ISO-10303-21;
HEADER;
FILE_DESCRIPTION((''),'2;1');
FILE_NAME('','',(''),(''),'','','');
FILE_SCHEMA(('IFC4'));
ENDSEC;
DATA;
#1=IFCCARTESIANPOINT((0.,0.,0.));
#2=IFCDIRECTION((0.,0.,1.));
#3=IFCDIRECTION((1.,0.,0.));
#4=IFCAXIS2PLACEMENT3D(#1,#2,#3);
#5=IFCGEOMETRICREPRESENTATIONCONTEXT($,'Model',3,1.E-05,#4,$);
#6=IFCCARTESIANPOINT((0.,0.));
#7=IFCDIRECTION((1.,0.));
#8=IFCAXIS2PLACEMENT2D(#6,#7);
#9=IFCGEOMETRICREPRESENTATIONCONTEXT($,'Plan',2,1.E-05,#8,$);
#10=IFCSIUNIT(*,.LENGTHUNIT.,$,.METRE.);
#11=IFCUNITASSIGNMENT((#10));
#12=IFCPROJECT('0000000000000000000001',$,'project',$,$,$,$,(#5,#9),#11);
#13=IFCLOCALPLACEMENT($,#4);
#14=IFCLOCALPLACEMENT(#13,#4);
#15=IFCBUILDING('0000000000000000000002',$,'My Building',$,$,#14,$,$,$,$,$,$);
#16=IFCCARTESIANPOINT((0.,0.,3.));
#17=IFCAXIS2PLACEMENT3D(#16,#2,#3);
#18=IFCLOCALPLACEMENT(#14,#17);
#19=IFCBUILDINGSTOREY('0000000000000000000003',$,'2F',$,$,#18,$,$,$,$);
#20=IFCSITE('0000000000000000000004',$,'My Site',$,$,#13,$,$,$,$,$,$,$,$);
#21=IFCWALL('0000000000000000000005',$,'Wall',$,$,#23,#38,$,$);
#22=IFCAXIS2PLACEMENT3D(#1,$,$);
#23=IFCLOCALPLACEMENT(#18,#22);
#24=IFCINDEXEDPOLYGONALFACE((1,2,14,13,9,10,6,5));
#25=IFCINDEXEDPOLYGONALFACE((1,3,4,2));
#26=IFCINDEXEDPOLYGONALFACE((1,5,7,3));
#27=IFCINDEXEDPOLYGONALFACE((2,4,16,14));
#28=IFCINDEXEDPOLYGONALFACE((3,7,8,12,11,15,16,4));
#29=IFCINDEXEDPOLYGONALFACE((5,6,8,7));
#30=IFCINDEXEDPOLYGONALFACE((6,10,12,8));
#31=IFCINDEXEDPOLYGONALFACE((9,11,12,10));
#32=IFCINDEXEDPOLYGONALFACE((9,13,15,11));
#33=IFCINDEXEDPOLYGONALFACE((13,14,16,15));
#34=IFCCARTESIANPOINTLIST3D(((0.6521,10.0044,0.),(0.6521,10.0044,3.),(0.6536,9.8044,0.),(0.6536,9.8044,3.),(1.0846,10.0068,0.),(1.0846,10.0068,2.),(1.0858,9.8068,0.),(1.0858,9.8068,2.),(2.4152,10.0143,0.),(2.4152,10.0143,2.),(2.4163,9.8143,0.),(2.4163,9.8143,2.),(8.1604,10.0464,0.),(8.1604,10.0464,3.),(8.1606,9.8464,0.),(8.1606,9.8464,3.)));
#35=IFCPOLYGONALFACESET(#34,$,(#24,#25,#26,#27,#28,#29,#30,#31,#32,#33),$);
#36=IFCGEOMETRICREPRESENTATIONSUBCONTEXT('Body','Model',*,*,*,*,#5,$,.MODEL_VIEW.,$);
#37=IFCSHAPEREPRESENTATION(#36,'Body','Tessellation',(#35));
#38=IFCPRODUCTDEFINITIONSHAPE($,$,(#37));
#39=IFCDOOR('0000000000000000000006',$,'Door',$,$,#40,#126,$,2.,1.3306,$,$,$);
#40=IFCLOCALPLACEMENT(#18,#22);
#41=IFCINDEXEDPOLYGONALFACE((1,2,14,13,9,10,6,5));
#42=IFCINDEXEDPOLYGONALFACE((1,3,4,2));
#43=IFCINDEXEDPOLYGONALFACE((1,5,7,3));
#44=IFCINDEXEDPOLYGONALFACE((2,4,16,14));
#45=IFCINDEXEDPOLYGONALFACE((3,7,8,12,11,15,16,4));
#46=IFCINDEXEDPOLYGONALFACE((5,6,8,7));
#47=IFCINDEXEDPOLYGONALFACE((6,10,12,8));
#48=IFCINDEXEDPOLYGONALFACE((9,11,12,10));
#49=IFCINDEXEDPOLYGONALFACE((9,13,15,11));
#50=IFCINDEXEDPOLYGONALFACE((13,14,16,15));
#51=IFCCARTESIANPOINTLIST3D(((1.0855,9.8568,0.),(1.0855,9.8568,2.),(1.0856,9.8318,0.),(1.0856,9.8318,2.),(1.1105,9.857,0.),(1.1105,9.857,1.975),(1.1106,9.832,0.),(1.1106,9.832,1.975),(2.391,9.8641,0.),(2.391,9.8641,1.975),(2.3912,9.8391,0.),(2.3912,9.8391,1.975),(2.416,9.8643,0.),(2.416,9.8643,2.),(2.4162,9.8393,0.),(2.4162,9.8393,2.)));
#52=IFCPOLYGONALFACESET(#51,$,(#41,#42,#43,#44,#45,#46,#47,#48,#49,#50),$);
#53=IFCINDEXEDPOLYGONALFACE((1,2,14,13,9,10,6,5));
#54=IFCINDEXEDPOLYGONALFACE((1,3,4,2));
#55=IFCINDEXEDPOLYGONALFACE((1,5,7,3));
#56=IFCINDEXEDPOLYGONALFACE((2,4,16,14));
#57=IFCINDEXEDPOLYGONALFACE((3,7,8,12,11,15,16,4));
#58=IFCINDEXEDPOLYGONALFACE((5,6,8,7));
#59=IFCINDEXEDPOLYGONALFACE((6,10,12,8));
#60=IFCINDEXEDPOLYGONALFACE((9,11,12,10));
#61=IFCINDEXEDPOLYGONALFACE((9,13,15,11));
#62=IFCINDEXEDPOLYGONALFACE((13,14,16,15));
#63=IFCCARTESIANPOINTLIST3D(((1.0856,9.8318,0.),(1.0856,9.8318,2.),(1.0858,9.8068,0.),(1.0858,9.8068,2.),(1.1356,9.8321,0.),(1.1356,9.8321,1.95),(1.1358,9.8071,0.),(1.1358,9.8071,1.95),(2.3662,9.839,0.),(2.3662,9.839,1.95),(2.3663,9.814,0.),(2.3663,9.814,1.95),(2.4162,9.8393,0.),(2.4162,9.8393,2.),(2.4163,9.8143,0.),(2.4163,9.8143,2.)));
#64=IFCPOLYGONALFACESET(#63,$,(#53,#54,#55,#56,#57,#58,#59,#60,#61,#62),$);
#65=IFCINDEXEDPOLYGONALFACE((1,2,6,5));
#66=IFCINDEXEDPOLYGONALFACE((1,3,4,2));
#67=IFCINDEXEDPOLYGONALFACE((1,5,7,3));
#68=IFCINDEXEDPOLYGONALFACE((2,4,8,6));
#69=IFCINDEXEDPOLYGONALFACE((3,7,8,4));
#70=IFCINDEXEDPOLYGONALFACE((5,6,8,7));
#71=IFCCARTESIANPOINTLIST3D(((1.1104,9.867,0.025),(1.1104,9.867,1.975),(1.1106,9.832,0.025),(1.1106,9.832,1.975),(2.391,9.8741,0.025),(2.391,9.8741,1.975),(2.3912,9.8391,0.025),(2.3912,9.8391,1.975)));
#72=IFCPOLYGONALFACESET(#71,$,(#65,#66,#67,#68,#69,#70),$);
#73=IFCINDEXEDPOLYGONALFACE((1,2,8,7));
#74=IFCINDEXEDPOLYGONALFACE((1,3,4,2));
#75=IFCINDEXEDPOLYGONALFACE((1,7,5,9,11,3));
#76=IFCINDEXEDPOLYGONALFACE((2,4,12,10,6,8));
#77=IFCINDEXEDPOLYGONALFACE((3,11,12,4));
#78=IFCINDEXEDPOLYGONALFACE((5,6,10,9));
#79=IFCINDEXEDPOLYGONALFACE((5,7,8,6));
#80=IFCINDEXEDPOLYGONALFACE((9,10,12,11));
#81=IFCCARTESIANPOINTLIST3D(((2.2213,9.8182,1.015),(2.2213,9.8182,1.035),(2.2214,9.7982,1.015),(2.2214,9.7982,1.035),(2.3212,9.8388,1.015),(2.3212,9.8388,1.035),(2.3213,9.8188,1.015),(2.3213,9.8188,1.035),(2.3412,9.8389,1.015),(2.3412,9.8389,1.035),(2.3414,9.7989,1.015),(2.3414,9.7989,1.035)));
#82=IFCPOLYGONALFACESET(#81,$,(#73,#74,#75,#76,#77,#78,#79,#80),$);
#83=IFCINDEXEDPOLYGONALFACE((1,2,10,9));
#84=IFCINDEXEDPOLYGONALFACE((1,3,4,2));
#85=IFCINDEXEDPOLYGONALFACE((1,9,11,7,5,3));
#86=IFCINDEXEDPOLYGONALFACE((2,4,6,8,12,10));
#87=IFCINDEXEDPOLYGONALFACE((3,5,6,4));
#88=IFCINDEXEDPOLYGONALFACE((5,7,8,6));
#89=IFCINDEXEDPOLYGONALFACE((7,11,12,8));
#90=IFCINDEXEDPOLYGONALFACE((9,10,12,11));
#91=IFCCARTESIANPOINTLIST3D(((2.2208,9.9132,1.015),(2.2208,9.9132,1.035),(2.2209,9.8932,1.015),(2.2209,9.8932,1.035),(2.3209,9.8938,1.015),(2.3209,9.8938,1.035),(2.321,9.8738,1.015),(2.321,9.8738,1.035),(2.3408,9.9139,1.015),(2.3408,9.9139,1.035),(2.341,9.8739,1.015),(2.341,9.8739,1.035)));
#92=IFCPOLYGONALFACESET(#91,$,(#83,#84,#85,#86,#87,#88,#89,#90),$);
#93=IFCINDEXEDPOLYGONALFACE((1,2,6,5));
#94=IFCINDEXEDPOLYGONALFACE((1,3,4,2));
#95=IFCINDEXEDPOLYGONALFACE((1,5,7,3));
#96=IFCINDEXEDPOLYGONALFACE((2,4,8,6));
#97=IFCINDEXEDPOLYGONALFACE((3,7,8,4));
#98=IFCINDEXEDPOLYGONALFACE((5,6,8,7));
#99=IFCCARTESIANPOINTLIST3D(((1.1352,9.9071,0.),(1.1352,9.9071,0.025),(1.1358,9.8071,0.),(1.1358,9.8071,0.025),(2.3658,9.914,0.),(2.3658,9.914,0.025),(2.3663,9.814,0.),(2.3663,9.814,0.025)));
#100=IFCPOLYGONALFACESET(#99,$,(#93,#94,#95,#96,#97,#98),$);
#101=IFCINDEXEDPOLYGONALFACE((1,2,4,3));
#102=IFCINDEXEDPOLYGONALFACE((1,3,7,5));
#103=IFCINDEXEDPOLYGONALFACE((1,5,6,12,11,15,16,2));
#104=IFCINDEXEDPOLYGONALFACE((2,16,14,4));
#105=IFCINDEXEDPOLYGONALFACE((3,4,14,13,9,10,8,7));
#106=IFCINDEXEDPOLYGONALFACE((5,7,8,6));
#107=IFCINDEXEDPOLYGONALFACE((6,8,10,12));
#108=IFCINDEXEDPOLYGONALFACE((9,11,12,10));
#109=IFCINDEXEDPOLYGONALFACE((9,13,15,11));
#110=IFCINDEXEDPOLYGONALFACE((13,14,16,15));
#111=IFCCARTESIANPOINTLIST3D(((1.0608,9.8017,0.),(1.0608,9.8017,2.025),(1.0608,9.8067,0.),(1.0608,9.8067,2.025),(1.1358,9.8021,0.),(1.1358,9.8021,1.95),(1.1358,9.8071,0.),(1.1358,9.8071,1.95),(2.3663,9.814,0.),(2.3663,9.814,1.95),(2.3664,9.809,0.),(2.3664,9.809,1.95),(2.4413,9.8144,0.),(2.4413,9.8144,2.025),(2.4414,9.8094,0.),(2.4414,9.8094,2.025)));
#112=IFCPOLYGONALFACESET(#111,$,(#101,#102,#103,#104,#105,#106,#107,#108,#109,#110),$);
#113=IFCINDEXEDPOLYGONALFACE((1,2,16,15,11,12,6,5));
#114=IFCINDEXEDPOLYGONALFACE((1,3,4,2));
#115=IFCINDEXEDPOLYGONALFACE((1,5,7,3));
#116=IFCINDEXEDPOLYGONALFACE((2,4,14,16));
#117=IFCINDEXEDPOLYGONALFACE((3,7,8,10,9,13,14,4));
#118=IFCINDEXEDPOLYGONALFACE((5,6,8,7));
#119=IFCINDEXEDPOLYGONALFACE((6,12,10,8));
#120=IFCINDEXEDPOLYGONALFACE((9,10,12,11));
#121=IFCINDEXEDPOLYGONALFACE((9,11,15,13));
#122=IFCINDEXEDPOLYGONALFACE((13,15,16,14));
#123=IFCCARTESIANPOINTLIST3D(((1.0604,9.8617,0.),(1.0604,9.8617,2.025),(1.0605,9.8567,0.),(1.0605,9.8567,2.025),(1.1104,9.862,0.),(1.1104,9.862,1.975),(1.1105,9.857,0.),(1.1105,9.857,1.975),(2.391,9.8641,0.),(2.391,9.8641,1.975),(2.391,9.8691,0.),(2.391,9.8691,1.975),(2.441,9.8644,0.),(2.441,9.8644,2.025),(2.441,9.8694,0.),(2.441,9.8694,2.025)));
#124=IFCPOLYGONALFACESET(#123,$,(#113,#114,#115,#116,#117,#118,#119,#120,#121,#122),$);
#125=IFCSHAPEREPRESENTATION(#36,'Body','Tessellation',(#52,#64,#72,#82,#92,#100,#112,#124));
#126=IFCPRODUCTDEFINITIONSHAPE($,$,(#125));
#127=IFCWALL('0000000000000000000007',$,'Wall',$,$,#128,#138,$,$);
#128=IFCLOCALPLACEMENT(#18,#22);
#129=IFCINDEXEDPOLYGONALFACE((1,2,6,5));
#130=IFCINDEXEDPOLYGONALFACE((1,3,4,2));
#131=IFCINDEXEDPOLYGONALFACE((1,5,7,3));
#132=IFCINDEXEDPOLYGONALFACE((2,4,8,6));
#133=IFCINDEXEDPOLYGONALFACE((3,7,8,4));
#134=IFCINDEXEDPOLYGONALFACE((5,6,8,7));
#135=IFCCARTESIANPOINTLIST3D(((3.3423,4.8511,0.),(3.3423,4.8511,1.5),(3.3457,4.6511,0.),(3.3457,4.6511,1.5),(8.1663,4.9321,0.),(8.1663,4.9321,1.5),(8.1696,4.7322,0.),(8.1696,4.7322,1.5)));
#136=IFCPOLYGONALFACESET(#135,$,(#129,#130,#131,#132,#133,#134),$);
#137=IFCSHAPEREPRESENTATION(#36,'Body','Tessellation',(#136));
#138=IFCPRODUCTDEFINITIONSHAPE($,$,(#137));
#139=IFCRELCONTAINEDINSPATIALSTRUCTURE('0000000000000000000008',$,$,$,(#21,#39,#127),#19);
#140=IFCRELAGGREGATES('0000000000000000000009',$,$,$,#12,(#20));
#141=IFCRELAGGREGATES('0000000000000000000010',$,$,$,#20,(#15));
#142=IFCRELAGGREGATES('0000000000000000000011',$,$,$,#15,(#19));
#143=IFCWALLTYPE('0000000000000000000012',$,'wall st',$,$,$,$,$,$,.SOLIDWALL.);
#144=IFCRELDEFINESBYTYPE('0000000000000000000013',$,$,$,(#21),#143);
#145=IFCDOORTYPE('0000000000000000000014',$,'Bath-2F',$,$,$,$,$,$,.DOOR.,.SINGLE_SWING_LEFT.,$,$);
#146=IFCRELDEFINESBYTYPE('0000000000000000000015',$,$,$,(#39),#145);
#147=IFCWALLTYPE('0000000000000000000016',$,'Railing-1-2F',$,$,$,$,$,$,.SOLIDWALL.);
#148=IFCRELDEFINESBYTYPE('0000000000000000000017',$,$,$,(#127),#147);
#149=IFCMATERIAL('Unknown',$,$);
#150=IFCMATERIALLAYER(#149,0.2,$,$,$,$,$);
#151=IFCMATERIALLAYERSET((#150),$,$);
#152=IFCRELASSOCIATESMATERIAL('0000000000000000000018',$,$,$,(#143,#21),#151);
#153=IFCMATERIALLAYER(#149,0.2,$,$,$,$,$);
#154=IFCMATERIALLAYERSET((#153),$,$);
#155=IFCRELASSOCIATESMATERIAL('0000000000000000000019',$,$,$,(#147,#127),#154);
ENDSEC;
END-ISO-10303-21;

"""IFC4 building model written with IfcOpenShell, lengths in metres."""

from ifc_helpers import new_model, entity, si_unit, frame, origin_with_axes, origin_2d_with_axis, place, context, subcontext, project, spatial, line, indexed_curve, outline, extrude, shape, source, transform, mapped, material, layer, layer_set, layer_usage, type_object, type_shapes, element, fill, save


model = new_model("IFC4")

# Units and contexts
model_context = context("Model", 3, precision=1e-05, world=origin_with_axes())
plan_context = context("Plan", 2, precision=1e-05, world=origin_2d_with_axis())
body_context_1 = subcontext(model_context, "Body", "Model", "MODEL_VIEW")
body_context_2 = subcontext(plan_context, "Body", "Plan", "PLAN_VIEW")
ifc_project = project(units=[si_unit("LENGTHUNIT", "METRE")], contexts=[model_context, plan_context])

# Site, building, storey
site_placement = place(None, origin_with_axes())
site = spatial("IfcSite", under=ifc_project, at=site_placement, Name="My Site")
building_placement = place(site_placement, origin_with_axes())
building = spatial("IfcBuilding", under=site, at=building_placement, Name="My Building")
storey_placement = place(building_placement, frame((0.0, 0.0, 3.0), z_axis=(0.0, 0.0, 1.0), x_axis=(1.0, 0.0, 0.0)))
storey = spatial("IfcBuildingStorey", under=building, at=storey_placement, Name="2F")

# Shared definitions
ifc_material = material(Name="Unknown")

# Shared definitions
ifc_layer_1 = layer(ifc_material, 0.2)
ifc_layer_set_1 = layer_set([ifc_layer_1])
wall_type_1 = type_object("IfcWallType", Name="wall st", PredefinedType="SOLIDWALL", material=ifc_layer_set_1)

# Wall, opening, door
ifc_layer_usage_1 = layer_usage(ifc_layer_set_1, "AXIS2", "POSITIVE", 0.0)
wall_1_placement = place(storey_placement, frame((0.4536, 9.8033, 0.0), z_axis=(0.0, 0.0, 1.0), x_axis=(0.999984, 0.00559, 0.0)))
wall_1 = element("IfcWall", 1, at=wall_1_placement, inside=storey, type_object=wall_type_1, material=ifc_layer_usage_1, Name="Wall", context=body_context_1, shape_type="SweptSolid", body=[
    extrude(outline(indexed_curve([(0.2, 0.0), (0.1997, 0.2), (7.708, 0.2), (7.7071, 0.0)], segments=[line(1, 2, 3, 4, 1)])), origin_with_axes(), (0.0, 0.0, 1.0), 3.0),
])
shared_shape_1 = source(origin_with_axes(), body_context_1, "Body", "SweptSolid", [
    extrude(outline(indexed_curve([(0.0, 0.0), (1.3306, 0.0), (1.3306, 2.0), (0.0, 2.0)], segments=[line(1, 2, 3, 4, 1)])), frame((0.0, -0.6, 0.0), z_axis=(0.0, -1.0, 0.0), x_axis=(1.0, 0.0, 0.0)), (0.0, 0.0, -1.0), 1.2),
])
opening_1_placement = place(wall_1_placement, frame((0.6322, 0.0, 0.0), z_axis=(0.0, 0.0, 1.0), x_axis=(1.0, 0.0, 0.0)))
opening_1 = element("IfcOpeningElement", 2, at=opening_1_placement, cuts=wall_1, PredefinedType="OPENING", context=body_context_1, shape_type="MappedRepresentation", body=[
    mapped(shared_shape_1, transform((0.0, 0.0, 0.0), x_axis=(1.0, 0.0, 0.0), y_axis=(0.0, 1.0, 0.0), z_axis=(0.0, 0.0, 1.0), scale=1.0)),
])
door_type_1 = type_object("IfcDoorType", Name="Bath-2F", OperationType="SINGLE_SWING_LEFT", PredefinedType="DOOR")
shared_shape_2 = source(origin_with_axes(), body_context_1, "Body", "SweptSolid", [
    extrude(outline(indexed_curve([(0.0, 0.0), (0.0, 2.0), (1.3306, 2.0), (1.3306, 0.0), (1.3056, 0.0), (1.3056, 1.975), (0.025, 1.975), (0.025, 0.0)], segments=[line(1, 2, 3, 4, 5, 6, 7, 8, 1)])), frame((0.0, 0.025, 0.0), z_axis=(0.0, -1.0, 0.0), x_axis=(1.0, 0.0, 0.0)), (0.0, 0.0, -1.0), 0.025),
    extrude(outline(indexed_curve([(0.0, 0.0), (0.0, 2.0), (1.3306, 2.0), (1.3306, 0.0), (1.2806, 0.0), (1.2806, 1.95), (0.05, 1.95), (0.05, 0.0)], segments=[line(1, 2, 3, 4, 5, 6, 7, 8, 1)])), frame((0.0, 0.0, 0.0), z_axis=(0.0, -1.0, 0.0), x_axis=(1.0, 0.0, 0.0)), (0.0, 0.0, -1.0), 0.025),
    extrude(outline(indexed_curve([(0.0, 0.0), (1.2806, 0.0), (1.2806, 0.035), (0.0, 0.035)], segments=[line(1, 2, 3, 4, 1)])), frame((0.025, 0.025, 0.025), z_axis=(0.0, 0.0, 1.0), x_axis=(1.0, 0.0, 0.0)), (0.0, 0.0, 1.0), 1.95),
    extrude(outline(indexed_curve([(0.0, 0.0), (0.0, -0.04), (-0.12, -0.04), (-0.12, -0.02), (-0.02, -0.02), (-0.02, 0.0)], segments=[line(1, 2, 3, 4, 5, 6, 1)])), frame((1.2556, 0.025, 1.015), z_axis=(0.0, 0.0, 1.0), x_axis=(1.0, 0.0, 0.0)), (0.0, 0.0, 1.0), 0.02),
    extrude(outline(indexed_curve([(0.0, 0.0), (0.0, 0.04), (-0.12, 0.04), (-0.12, 0.02), (-0.02, 0.02), (-0.02, 0.0)], segments=[line(1, 2, 3, 4, 5, 6, 1)])), frame((1.2556, 0.06, 1.015), z_axis=(0.0, 0.0, 1.0), x_axis=(1.0, 0.0, 0.0)), (0.0, 0.0, 1.0), 0.02),
    extrude(outline(indexed_curve([(0.0, 0.0), (1.2306, 0.0), (1.2306, 0.1), (0.0, 0.1)], segments=[line(1, 2, 3, 4, 1)])), frame((0.05, 0.0, 0.0), z_axis=(0.0, 0.0, 1.0), x_axis=(1.0, 0.0, 0.0)), (0.0, 0.0, 1.0), 0.025),
    extrude(outline(indexed_curve([(0.0, 0.0), (0.0, 2.025), (1.3806, 2.025), (1.3806, 0.0), (1.3056, 0.0), (1.3056, 1.95), (0.075, 1.95), (0.075, 0.0)], segments=[line(1, 2, 3, 4, 5, 6, 7, 8, 1)])), frame((-0.025, -0.005, 0.0), z_axis=(0.0, -1.0, 0.0), x_axis=(1.0, 0.0, 0.0)), (0.0, 0.0, -1.0), 0.005),
    extrude(outline(indexed_curve([(0.0, 0.0), (0.0, 2.025), (1.3806, 2.025), (1.3806, 0.0), (1.3306, 0.0), (1.3306, 1.975), (0.05, 1.975), (0.05, 0.0)], segments=[line(1, 2, 3, 4, 5, 6, 7, 8, 1)])), frame((-0.025, 0.05, 0.0), z_axis=(0.0, -1.0, 0.0), x_axis=(1.0, 0.0, 0.0)), (0.0, 0.0, -1.0), 0.005),
])
shared_shape_3 = source(origin_with_axes(), body_context_2, "Body", "Curve2D", [
    entity("IfcIndexedPolyCurve", entity("IfcCartesianPointList2D", [[0.0, 0.0], [0.0, 0.05], [0.025, 0.05], [0.025, 0.025], [0.05, 0.025], [0.05, 0.0]]), [entity("IfcLineIndex", [1, 2, 3, 4, 5, 6, 1])]),
    entity("IfcIndexedPolyCurve", entity("IfcCartesianPointList2D", [[1.3306, 0.0], [1.3306, 0.05], [1.3056, 0.05], [1.3056, 0.025], [1.2806, 0.025], [1.2806, 0.0]]), [entity("IfcLineIndex", [1, 2, 3, 4, 5, 6, 1])]),
    entity("IfcTrimmedCurve", entity("IfcEllipse", entity("IfcAxis2Placement2D", entity("IfcCartesianPoint", [0.06, 0.05]), entity("IfcDirection", [1.0, 0.0])), 1.2456, 1.2806), [entity("IfcCartesianPoint", [1.3056, 0.05])], [entity("IfcCartesianPoint", [0.06, 1.3306])], True, "CARTESIAN"),
    entity("IfcIndexedPolyCurve", entity("IfcCartesianPointList2D", [[0.025, 0.05], [0.06, 0.05], [0.06, 1.3306], [0.025, 1.3306]]), [entity("IfcLineIndex", [1, 2, 3, 4, 1])]),
])
type_shapes(door_type_1, [shared_shape_2, shared_shape_3])
door_1_placement = place(opening_1_placement, frame((0.0, 0.0, 0.0), z_axis=(0.0, 0.0, 1.0), x_axis=(1.0, 0.0, 0.0)))
door_1 = element("IfcDoor", 3, at=door_1_placement, inside=storey, type_object=door_type_1, Name="Door", OverallHeight=2.0, OverallWidth=1.3306, shapes=[
    shape(body_context_1, "Body", "MappedRepresentation", [mapped(shared_shape_2, transform((0.0, 0.0, 0.0), x_axis=(1.0, 0.0, 0.0), y_axis=(0.0, 1.0, 0.0), z_axis=(0.0, 0.0, 1.0), scale=1.0))]),
    shape(body_context_2, "Body", "MappedRepresentation", [mapped(shared_shape_3, transform((0.0, 0.0, 0.0), x_axis=(1.0, 0.0, 0.0), y_axis=(0.0, 1.0, 0.0), z_axis=(0.0, 0.0, 1.0), scale=1.0))]),
])
fill(opening_1, door_1)

# Wall
ifc_layer_2 = layer(ifc_material, 0.2)
ifc_layer_set_2 = layer_set([ifc_layer_2])
ifc_layer_usage_2 = layer_usage(ifc_layer_set_2, "AXIS2", "POSITIVE", 0.0)
wall_type_2 = type_object("IfcWallType", Name="Railing-1-2F", PredefinedType="SOLIDWALL", material=ifc_layer_set_2)
wall_2_placement = place(storey_placement, frame((8.1663, 4.9321, 0.0), z_axis=(0.0, 0.0, 1.0), x_axis=(-0.999859, -0.016799, 0.0)))
element("IfcWall", 4, at=wall_2_placement, inside=storey, type_object=wall_type_2, material=ifc_layer_usage_2, Name="Wall", context=body_context_1, shape_type="SweptSolid", body=[
    extrude(outline(indexed_curve([(0.0, 0.0), (0.0, 0.2), (4.8247, 0.2), (4.8247, 0.0)], segments=[line(1, 2, 3, 4, 1)])), origin_with_axes(), (0.0, 0.0, 1.0), 1.5),
])

save(model, "model.ifc")
